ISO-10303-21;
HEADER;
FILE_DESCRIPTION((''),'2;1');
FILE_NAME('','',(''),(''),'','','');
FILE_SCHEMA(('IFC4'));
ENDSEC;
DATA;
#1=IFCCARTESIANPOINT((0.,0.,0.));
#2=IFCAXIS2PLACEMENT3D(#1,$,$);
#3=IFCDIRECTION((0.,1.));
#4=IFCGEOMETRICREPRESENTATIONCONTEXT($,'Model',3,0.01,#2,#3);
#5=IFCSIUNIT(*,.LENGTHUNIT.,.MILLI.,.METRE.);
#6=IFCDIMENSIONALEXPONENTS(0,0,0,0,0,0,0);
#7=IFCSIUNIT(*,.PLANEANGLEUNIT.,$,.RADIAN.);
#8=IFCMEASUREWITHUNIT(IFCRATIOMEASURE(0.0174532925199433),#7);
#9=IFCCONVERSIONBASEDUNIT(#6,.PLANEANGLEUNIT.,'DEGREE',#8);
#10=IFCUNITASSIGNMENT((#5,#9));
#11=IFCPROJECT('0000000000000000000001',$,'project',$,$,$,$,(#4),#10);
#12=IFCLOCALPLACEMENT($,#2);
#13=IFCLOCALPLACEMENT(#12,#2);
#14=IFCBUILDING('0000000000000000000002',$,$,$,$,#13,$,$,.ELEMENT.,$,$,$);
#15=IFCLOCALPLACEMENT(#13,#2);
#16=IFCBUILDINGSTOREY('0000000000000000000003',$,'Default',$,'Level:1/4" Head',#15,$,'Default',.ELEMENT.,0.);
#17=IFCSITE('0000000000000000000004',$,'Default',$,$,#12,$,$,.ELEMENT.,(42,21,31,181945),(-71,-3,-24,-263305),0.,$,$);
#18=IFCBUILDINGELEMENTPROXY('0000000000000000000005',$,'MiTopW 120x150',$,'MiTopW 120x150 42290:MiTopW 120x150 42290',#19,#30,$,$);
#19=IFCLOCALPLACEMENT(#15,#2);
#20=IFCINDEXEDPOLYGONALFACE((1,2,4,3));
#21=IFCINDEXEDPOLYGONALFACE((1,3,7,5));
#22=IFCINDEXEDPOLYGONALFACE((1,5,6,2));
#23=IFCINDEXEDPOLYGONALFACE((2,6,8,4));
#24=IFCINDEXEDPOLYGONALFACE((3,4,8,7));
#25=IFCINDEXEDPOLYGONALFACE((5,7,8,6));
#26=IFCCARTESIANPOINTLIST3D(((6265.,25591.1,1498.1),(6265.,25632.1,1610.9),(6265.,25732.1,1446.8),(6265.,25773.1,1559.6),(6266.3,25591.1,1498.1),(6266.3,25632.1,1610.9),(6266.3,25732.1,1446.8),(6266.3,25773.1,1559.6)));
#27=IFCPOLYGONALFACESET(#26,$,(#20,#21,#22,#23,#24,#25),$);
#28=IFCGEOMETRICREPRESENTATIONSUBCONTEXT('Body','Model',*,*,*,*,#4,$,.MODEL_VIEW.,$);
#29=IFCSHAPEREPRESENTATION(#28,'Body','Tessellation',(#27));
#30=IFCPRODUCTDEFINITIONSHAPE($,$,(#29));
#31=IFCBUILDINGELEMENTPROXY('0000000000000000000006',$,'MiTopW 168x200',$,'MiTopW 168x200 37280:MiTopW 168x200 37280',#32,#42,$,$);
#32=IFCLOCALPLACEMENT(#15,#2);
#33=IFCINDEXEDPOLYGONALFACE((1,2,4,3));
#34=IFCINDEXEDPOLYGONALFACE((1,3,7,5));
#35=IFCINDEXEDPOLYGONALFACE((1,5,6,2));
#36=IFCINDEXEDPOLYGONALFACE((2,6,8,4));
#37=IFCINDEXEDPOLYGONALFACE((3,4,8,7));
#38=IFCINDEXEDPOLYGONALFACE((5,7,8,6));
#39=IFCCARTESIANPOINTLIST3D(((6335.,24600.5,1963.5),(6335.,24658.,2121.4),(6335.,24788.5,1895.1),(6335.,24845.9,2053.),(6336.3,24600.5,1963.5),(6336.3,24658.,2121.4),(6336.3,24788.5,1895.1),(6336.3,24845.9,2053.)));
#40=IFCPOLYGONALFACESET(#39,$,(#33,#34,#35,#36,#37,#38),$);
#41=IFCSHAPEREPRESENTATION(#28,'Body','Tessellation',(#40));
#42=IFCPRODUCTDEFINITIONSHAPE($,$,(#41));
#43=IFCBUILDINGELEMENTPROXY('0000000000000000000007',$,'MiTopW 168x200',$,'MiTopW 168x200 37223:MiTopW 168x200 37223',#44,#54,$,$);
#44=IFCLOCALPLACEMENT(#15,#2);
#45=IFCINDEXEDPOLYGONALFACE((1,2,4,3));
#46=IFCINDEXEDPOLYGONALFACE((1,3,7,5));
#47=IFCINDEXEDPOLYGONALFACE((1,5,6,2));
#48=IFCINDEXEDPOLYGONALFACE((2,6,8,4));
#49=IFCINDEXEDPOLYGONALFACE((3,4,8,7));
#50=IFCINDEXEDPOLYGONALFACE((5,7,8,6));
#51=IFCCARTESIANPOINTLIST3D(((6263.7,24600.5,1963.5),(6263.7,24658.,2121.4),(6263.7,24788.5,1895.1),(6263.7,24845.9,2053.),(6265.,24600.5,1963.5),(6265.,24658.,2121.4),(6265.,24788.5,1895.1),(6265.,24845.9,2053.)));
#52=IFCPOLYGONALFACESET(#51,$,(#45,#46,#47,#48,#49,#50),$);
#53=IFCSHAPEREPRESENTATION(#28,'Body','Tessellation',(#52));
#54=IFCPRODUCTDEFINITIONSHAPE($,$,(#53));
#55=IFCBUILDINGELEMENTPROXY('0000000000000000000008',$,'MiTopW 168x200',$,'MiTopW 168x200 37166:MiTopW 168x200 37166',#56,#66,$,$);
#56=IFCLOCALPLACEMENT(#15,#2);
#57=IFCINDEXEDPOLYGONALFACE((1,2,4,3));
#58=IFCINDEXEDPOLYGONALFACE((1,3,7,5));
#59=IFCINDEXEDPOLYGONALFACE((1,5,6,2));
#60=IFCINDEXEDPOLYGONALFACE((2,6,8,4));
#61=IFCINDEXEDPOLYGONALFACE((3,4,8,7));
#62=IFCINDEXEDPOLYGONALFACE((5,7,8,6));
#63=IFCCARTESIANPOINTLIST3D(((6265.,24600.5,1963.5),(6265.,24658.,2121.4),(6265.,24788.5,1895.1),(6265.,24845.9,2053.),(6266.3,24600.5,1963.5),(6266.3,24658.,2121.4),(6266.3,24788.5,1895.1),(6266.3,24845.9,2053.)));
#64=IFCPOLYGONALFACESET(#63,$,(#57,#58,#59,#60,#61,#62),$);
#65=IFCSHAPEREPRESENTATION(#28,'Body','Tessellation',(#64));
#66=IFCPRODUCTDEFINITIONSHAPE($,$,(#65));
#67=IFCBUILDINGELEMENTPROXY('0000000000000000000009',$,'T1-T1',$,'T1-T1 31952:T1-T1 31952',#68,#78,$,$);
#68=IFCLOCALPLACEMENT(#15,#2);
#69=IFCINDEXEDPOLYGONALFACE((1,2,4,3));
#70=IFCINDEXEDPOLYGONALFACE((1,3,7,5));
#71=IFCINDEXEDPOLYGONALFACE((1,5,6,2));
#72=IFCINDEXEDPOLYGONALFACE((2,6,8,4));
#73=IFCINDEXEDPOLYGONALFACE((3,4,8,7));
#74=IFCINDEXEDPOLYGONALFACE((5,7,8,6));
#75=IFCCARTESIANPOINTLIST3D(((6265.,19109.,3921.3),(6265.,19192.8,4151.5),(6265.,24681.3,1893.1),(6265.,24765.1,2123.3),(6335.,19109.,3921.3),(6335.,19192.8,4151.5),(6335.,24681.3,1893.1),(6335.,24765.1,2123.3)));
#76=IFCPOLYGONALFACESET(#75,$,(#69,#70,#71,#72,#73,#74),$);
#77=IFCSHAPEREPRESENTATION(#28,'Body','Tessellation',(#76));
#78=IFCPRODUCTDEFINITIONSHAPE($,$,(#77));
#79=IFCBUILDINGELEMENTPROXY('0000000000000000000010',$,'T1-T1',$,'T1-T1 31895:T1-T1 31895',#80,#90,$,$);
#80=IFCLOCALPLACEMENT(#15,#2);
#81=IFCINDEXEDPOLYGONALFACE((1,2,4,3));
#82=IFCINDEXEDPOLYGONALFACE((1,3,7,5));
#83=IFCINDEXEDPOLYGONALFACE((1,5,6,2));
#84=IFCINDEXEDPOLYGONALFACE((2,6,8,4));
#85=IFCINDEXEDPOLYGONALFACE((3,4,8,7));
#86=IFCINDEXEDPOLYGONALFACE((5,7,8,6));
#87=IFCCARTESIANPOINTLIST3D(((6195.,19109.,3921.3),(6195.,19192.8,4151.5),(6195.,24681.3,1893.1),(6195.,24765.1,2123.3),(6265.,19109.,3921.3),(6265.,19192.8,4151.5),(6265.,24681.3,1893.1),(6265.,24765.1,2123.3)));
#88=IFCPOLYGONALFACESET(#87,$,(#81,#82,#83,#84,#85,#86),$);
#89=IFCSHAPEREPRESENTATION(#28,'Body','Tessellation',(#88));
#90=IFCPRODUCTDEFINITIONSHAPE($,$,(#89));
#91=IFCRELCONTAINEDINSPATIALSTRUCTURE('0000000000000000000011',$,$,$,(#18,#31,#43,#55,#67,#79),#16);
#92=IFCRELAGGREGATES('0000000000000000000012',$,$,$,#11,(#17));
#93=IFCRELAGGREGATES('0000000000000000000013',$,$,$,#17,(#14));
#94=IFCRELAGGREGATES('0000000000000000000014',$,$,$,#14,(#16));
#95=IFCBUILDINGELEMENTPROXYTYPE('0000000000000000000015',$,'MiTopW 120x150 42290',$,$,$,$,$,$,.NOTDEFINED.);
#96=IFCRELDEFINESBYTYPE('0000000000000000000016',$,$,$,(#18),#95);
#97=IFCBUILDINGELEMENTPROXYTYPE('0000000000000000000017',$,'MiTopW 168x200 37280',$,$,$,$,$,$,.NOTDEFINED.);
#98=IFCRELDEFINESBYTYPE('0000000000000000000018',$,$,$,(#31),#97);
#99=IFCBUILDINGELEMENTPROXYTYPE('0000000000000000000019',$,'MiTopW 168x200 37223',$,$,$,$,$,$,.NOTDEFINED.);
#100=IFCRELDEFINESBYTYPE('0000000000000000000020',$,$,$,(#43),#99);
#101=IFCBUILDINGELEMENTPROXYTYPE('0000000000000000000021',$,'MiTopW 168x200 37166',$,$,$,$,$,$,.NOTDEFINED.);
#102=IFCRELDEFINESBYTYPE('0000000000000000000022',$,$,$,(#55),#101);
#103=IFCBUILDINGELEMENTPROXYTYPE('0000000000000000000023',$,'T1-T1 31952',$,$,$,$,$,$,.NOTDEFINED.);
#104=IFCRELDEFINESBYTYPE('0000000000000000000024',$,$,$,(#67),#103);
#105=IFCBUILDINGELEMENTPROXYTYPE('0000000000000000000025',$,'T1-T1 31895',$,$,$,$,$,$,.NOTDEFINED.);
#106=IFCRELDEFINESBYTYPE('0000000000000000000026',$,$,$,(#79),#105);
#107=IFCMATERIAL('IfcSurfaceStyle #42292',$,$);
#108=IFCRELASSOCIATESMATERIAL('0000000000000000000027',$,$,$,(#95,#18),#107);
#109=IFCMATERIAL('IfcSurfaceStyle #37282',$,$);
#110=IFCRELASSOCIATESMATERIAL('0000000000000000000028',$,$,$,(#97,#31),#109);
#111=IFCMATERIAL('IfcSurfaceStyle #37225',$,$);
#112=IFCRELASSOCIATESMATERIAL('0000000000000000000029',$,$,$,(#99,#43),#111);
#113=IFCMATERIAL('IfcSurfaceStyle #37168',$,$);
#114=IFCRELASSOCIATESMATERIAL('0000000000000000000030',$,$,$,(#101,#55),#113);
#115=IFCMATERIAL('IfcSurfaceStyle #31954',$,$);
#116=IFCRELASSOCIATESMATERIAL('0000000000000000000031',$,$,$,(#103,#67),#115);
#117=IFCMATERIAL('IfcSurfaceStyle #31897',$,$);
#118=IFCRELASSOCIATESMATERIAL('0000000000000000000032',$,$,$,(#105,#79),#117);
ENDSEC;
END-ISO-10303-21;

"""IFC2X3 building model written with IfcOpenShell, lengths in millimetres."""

from ifc_helpers import new_model, entity, si_unit, converted_unit, direction, frame, origin, place, context, subcontext, project, spatial, polyline, outline, extrude, source, transform, mapped, material, type_object, type_shapes, element, save


model = new_model("IFC2X3")

# Units and contexts
model_context = context("Model", 3, precision=0.01, world=origin(), true_north=direction((0.0, 1.0)))
body_context = subcontext(model_context, "Body", "Model", "MODEL_VIEW")
ifc_project = project(units=[si_unit("LENGTHUNIT", "METRE", prefix="MILLI"), converted_unit("PLANEANGLEUNIT", "DEGREE", entity("IfcRatioMeasure", 0.0174532925199433), si_unit("PLANEANGLEUNIT", "RADIAN"), dimensions=[0, 0, 0, 0, 0, 0, 0])], contexts=[model_context])

# Site, building, storey
site_placement = place(None, origin())
site = spatial("IfcSite", under=ifc_project, at=site_placement, Name="Default", CompositionType="ELEMENT", RefLatitude=(42, 21, 31, 181945), RefLongitude=(-71, -3, -24, -263305), RefElevation=0.0)
building_placement = place(site_placement, origin())
building = spatial("IfcBuilding", under=site, at=building_placement, CompositionType="ELEMENT")
storey_placement = place(building_placement, origin())
storey = spatial("IfcBuildingStorey", under=building, at=storey_placement, Name="Default", ObjectType="Level:1/4\" Head", LongName="Default", CompositionType="ELEMENT", Elevation=0.0)

# Building element proxies
ifc_material_1 = material(Name="IfcSurfaceStyle #42292")
building_element_proxy_type_1 = type_object("IfcBuildingElementProxyType", Name="MiTopW 120x150 42290", PredefinedType="NOTDEFINED", material=ifc_material_1)
shared_shape_1 = source(origin(), body_context, "Body", "SweptSolid", [
    extrude(outline(polyline([(-75.0, -60.0), (75.0, -60.0), (75.0, 60.0), (-75.0, 60.0), (-75.0, -60.0)])), frame((75.0, 60.0, 0.0), z_axis=(0.0, 0.0, 1.0), x_axis=(-1.0, 0.0, 0.0)), (0.0, 0.0, 1.0), 1.3),
])
type_shapes(building_element_proxy_type_1, [shared_shape_1])
proxy_1_placement = place(building_placement, frame((6266.3, 25732.1, 1446.8), z_axis=(-1.0, 0.0, 0.0), x_axis=(0.0, -0.939693, 0.34202)))
element("IfcBuildingElementProxy", 1, at=proxy_1_placement, inside=storey, type_object=building_element_proxy_type_1, material=ifc_material_1, Name="MiTopW 120x150", ObjectType="MiTopW 120x150 42290:MiTopW 120x150 42290", context=body_context, shape_type="MappedRepresentation", body=[
    mapped(shared_shape_1, transform((0.0, 0.0, 0.0), scale=1.0)),
])
ifc_material_2 = material(Name="IfcSurfaceStyle #37282")
building_element_proxy_type_2 = type_object("IfcBuildingElementProxyType", Name="MiTopW 168x200 37280", PredefinedType="NOTDEFINED", material=ifc_material_2)
shared_shape_2 = source(origin(), body_context, "Body", "SweptSolid", [
    extrude(outline(polyline([(-100.0, -84.0), (100.0, -84.0), (100.0, 84.0), (-100.0, 84.0), (-100.0, -84.0)])), frame((100.0, 84.0, 0.0), z_axis=(0.0, 0.0, 1.0), x_axis=(-1.0, 0.0, 0.0)), (0.0, 0.0, 1.0), 1.3),
])
type_shapes(building_element_proxy_type_2, [shared_shape_2])
proxy_2_placement = place(building_placement, frame((6336.3, 24788.5, 1895.1), z_axis=(-1.0, 0.0, 0.0), x_axis=(0.0, -0.939693, 0.34202)))
element("IfcBuildingElementProxy", 2, at=proxy_2_placement, inside=storey, type_object=building_element_proxy_type_2, material=ifc_material_2, Name="MiTopW 168x200", ObjectType="MiTopW 168x200 37280:MiTopW 168x200 37280", context=body_context, shape_type="MappedRepresentation", body=[
    mapped(shared_shape_2, transform((0.0, 0.0, 0.0), scale=1.0)),
])
ifc_material_3 = material(Name="IfcSurfaceStyle #37225")
building_element_proxy_type_3 = type_object("IfcBuildingElementProxyType", Name="MiTopW 168x200 37223", PredefinedType="NOTDEFINED", material=ifc_material_3)
shared_shape_3 = source(origin(), body_context, "Body", "SweptSolid", [
    extrude(outline(polyline([(-100.0, -84.0), (100.0, -84.0), (100.0, 84.0), (-100.0, 84.0), (-100.0, -84.0)])), frame((100.0, 84.0, 0.0), z_axis=(0.0, 0.0, 1.0), x_axis=(-1.0, 0.0, 0.0)), (0.0, 0.0, 1.0), 1.3),
])
type_shapes(building_element_proxy_type_3, [shared_shape_3])
proxy_3_placement = place(building_placement, frame((6265.0, 24788.5, 1895.1), z_axis=(-1.0, 0.0, 0.0), x_axis=(0.0, -0.939693, 0.34202)))
element("IfcBuildingElementProxy", 3, at=proxy_3_placement, inside=storey, type_object=building_element_proxy_type_3, material=ifc_material_3, Name="MiTopW 168x200", ObjectType="MiTopW 168x200 37223:MiTopW 168x200 37223", context=body_context, shape_type="MappedRepresentation", body=[
    mapped(shared_shape_3, transform((0.0, 0.0, 0.0), scale=1.0)),
])
ifc_material_4 = material(Name="IfcSurfaceStyle #37168")
building_element_proxy_type_4 = type_object("IfcBuildingElementProxyType", Name="MiTopW 168x200 37166", PredefinedType="NOTDEFINED", material=ifc_material_4)
shared_shape_4 = source(origin(), body_context, "Body", "SweptSolid", [
    extrude(outline(polyline([(-100.0, -84.0), (100.0, -84.0), (100.0, 84.0), (-100.0, 84.0), (-100.0, -84.0)])), frame((100.0, 84.0, 0.0), z_axis=(0.0, 0.0, 1.0), x_axis=(-1.0, 0.0, 0.0)), (0.0, 0.0, 1.0), 1.3),
])
type_shapes(building_element_proxy_type_4, [shared_shape_4])
proxy_4_placement = place(building_placement, frame((6266.3, 24788.5, 1895.1), z_axis=(-1.0, 0.0, 0.0), x_axis=(0.0, -0.939693, 0.34202)))
element("IfcBuildingElementProxy", 4, at=proxy_4_placement, inside=storey, type_object=building_element_proxy_type_4, material=ifc_material_4, Name="MiTopW 168x200", ObjectType="MiTopW 168x200 37166:MiTopW 168x200 37166", context=body_context, shape_type="MappedRepresentation", body=[
    mapped(shared_shape_4, transform((0.0, 0.0, 0.0), scale=1.0)),
])
ifc_material_5 = material(Name="IfcSurfaceStyle #31954")
building_element_proxy_type_5 = type_object("IfcBuildingElementProxyType", Name="T1-T1 31952", PredefinedType="NOTDEFINED", material=ifc_material_5)
shared_shape_5 = source(origin(), body_context, "Body", "SweptSolid", [
    extrude(outline(polyline([(-2965.0, -122.5), (2965.0, -122.5), (2965.0, 122.5), (-2965.0, 122.5), (-2965.0, -122.5)])), frame((2965.0, 122.5, 0.0), z_axis=(0.0, 0.0, 1.0), x_axis=(-1.0, 0.0, 0.0)), (0.0, 0.0, 1.0), 70.0),
])
type_shapes(building_element_proxy_type_5, [shared_shape_5])
proxy_5_placement = place(building_placement, frame((6335.0, 24681.3, 1893.1), z_axis=(-1.0, 0.0, 0.0), x_axis=(0.0, -0.939693, 0.34202)))
element("IfcBuildingElementProxy", 5, at=proxy_5_placement, inside=storey, type_object=building_element_proxy_type_5, material=ifc_material_5, Name="T1-T1", ObjectType="T1-T1 31952:T1-T1 31952", context=body_context, shape_type="MappedRepresentation", body=[
    mapped(shared_shape_5, transform((0.0, 0.0, 0.0), scale=1.0)),
])
ifc_material_6 = material(Name="IfcSurfaceStyle #31897")
building_element_proxy_type_6 = type_object("IfcBuildingElementProxyType", Name="T1-T1 31895", PredefinedType="NOTDEFINED", material=ifc_material_6)
shared_shape_6 = source(origin(), body_context, "Body", "SweptSolid", [
    extrude(outline(polyline([(-2965.0, -122.5), (2965.0, -122.5), (2965.0, 122.5), (-2965.0, 122.5), (-2965.0, -122.5)])), frame((2965.0, 122.5, 0.0), z_axis=(0.0, 0.0, 1.0), x_axis=(-1.0, 0.0, 0.0)), (0.0, 0.0, 1.0), 70.0),
])
type_shapes(building_element_proxy_type_6, [shared_shape_6])
proxy_6_placement = place(building_placement, frame((6265.0, 24681.3, 1893.1), z_axis=(-1.0, 0.0, 0.0), x_axis=(0.0, -0.939693, 0.34202)))
element("IfcBuildingElementProxy", 6, at=proxy_6_placement, inside=storey, type_object=building_element_proxy_type_6, material=ifc_material_6, Name="T1-T1", ObjectType="T1-T1 31895:T1-T1 31895", context=body_context, shape_type="MappedRepresentation", body=[
    mapped(shared_shape_6, transform((0.0, 0.0, 0.0), scale=1.0)),
])

save(model, "model.ifc")
